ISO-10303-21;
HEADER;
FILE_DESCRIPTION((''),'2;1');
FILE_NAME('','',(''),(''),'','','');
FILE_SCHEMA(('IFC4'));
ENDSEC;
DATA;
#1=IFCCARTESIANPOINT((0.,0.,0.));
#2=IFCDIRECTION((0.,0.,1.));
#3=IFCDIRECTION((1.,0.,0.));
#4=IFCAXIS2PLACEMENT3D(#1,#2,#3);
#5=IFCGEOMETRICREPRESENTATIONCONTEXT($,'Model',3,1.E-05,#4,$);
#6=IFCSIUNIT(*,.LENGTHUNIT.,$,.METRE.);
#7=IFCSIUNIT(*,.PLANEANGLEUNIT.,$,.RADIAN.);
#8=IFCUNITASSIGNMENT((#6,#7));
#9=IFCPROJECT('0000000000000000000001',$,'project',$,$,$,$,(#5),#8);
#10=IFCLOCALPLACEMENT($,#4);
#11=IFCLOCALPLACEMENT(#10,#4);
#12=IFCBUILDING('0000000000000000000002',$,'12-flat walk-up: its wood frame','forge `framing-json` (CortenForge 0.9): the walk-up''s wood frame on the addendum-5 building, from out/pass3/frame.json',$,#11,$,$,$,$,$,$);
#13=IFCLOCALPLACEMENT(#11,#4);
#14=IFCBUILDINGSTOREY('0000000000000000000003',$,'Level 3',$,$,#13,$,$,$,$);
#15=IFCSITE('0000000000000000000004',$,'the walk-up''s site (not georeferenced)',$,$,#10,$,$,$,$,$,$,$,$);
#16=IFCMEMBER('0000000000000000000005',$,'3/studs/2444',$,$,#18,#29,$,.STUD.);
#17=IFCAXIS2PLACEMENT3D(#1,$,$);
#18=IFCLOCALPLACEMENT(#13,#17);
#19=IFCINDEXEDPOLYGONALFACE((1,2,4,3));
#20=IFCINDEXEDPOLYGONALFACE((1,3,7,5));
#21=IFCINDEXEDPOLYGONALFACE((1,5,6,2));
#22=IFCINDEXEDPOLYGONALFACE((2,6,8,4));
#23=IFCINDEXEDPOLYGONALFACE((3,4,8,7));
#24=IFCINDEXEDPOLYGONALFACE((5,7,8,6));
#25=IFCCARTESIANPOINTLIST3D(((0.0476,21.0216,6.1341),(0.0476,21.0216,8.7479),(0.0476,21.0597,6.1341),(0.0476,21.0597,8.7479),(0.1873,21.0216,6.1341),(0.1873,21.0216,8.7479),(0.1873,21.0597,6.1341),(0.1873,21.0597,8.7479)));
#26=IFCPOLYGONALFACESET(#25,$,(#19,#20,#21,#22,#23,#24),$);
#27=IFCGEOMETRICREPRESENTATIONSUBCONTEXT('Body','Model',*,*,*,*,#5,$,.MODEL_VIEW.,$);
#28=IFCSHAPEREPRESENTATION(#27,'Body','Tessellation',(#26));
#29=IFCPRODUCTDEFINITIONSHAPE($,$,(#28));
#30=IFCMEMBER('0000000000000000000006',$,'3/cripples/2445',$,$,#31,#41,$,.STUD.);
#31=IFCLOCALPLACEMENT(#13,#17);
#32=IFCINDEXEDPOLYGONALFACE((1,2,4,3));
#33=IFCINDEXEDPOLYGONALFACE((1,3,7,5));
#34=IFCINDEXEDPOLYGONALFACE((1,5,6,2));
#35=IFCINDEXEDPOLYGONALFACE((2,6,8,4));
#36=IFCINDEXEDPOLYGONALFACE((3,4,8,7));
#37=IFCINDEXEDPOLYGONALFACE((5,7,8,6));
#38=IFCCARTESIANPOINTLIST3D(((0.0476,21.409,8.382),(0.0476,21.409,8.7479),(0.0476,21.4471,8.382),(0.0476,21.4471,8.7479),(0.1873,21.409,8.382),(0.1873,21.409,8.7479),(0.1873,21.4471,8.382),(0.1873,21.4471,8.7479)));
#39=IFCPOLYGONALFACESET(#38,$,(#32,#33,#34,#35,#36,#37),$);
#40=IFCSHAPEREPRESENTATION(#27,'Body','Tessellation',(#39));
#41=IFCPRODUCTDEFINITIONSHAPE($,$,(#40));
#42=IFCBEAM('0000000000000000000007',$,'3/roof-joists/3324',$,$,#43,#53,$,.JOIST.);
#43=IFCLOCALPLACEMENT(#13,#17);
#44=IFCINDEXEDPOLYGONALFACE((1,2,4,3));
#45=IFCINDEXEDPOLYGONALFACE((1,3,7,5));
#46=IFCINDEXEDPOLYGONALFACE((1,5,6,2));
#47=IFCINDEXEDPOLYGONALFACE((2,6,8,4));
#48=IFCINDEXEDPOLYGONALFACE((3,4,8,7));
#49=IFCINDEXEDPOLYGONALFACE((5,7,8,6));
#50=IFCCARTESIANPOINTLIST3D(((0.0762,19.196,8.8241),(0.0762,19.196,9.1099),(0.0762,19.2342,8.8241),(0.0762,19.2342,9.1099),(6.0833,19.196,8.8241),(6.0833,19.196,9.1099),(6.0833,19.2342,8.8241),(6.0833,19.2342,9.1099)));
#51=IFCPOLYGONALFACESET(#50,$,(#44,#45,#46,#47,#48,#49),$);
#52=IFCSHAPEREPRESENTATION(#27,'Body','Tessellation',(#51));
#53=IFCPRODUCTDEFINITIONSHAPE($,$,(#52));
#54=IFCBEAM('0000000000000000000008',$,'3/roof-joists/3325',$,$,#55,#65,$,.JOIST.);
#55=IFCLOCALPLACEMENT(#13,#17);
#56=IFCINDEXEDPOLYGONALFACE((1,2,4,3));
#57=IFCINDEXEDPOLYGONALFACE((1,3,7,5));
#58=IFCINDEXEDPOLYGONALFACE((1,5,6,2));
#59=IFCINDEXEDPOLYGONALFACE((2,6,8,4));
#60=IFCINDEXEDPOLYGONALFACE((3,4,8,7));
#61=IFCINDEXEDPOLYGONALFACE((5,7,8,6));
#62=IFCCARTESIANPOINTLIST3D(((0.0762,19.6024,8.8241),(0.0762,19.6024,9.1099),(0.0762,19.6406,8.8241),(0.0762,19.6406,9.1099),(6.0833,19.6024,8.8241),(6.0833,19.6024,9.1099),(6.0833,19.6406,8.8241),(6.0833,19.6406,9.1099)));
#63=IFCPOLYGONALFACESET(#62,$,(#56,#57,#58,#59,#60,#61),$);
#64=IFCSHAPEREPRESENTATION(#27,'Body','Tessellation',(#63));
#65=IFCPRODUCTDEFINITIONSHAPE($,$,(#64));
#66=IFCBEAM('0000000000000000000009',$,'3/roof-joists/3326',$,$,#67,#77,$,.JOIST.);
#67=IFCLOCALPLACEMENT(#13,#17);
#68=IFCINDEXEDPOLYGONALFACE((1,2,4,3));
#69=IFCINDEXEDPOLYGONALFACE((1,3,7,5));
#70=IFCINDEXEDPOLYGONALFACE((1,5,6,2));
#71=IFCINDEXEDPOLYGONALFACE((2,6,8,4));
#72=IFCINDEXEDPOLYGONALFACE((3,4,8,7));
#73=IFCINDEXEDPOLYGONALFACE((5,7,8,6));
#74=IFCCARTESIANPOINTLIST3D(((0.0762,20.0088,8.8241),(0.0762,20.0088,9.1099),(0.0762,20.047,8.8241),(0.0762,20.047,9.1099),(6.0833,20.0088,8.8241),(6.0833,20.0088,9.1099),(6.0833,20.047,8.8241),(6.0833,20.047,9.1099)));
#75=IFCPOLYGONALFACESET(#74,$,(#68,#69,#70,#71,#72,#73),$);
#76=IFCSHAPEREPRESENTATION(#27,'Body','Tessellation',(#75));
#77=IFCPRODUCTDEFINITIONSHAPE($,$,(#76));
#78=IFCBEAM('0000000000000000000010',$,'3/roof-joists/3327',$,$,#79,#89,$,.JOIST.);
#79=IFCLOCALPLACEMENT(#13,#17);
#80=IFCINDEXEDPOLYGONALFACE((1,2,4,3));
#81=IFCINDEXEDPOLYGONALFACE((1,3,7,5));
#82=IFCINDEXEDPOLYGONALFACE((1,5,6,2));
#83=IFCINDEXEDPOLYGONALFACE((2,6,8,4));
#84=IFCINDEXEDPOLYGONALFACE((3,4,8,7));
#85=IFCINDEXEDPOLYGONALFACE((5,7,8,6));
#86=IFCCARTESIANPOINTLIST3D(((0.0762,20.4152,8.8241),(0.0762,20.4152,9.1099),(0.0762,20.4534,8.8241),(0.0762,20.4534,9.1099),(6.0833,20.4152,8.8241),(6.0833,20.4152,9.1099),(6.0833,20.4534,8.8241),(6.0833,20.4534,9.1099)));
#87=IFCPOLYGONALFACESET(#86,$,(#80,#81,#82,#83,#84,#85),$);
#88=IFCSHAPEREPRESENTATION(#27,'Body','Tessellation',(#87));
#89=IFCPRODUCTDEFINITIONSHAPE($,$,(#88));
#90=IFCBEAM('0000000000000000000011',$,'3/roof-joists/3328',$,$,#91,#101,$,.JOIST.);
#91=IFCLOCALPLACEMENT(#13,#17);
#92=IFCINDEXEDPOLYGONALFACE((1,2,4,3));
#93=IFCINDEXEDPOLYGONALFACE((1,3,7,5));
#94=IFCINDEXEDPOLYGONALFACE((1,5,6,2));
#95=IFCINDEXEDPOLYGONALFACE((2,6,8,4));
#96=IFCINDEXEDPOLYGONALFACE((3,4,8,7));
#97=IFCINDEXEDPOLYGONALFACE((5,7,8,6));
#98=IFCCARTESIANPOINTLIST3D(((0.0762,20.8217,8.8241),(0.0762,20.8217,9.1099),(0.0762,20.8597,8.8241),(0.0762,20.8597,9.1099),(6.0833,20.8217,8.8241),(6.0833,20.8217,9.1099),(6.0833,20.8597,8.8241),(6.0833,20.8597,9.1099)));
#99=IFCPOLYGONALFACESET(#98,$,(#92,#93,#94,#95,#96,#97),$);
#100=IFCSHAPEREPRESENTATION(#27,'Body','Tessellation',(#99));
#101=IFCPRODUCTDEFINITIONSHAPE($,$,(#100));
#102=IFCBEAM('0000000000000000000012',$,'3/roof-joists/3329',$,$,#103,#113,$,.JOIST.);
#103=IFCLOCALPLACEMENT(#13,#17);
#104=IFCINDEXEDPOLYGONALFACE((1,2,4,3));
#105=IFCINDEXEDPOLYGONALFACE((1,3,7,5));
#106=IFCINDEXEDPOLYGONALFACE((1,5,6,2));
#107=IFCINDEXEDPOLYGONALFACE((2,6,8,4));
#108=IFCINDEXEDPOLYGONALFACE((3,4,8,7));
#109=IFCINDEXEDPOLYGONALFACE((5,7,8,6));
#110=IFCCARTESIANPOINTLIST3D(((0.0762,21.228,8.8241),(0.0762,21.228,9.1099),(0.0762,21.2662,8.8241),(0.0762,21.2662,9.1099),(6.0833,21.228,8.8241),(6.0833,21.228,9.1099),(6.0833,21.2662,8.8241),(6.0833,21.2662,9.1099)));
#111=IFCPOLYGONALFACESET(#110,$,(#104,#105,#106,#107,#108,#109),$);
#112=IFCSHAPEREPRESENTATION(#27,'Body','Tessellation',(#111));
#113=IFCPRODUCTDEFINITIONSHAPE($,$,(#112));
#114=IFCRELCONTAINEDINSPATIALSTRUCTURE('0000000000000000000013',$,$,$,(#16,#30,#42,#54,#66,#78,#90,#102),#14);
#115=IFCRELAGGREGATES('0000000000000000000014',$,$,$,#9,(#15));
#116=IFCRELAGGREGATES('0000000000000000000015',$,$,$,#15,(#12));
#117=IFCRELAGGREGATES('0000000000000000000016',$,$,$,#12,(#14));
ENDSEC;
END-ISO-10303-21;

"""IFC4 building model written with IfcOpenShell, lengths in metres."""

from ifc_helpers import new_model, si_unit, frame, frame_2d, origin, origin_with_axes, place, context, subcontext, project, spatial, rectangle, extrude, element, save


model = new_model("IFC4")

# Units and contexts
model_context = context("Model", 3, precision=1e-05, world=origin_with_axes())
body_context = subcontext(model_context, "Body", "Model", "MODEL_VIEW")
ifc_project = project(units=[si_unit("LENGTHUNIT", "METRE"), si_unit("PLANEANGLEUNIT", "RADIAN")], contexts=[model_context])

# Site, building, storey
site_placement = place(None, origin_with_axes())
site = spatial("IfcSite", under=ifc_project, at=site_placement, Name="the walk-up's site (not georeferenced)")
building_placement = place(site_placement, origin_with_axes())
building = spatial("IfcBuilding", under=site, at=building_placement, Name="12-flat walk-up: its wood frame", Description="forge `framing-json` (CortenForge 0.9): the walk-up's wood frame on the addendum-5 building, from out/pass3/frame.json")
storey_placement = place(building_placement, origin_with_axes())
storey = spatial("IfcBuildingStorey", under=building, at=storey_placement, Name="Level 3")

# Members
member_1_placement = place(storey_placement, frame((0.0476, 21.0216, 6.1341), z_axis=(0.0, 0.0, 1.0), x_axis=(1.0, 0.0, 0.0)))
element("IfcMember", 1, at=member_1_placement, inside=storey, Name="3/studs/2444", PredefinedType="STUD", context=body_context, shape_type="SweptSolid", body=[
    extrude(rectangle(XDim=0.1397, YDim=0.0381, at=frame_2d((0.0698, 0.0191))), origin(), (0.0, 0.0, 1.0), 2.6138),
])
member_2_placement = place(storey_placement, frame((0.0476, 21.409, 8.382), z_axis=(0.0, 0.0, 1.0), x_axis=(1.0, 0.0, 0.0)))
element("IfcMember", 2, at=member_2_placement, inside=storey, Name="3/cripples/2445", PredefinedType="STUD", context=body_context, shape_type="SweptSolid", body=[
    extrude(rectangle(XDim=0.1397, YDim=0.0381, at=frame_2d((0.0698, 0.0191))), origin(), (0.0, 0.0, 1.0), 0.3659),
])

# Beams
for number, where, z_axis, x_axis, name in (
    (3, (0.0762, 19.196, 8.8241), (0.0, 0.0, 1.0), (1.0, 0.0, 0.0), "3/roof-joists/3324"),
    (4, (0.0762, 19.6025, 8.8241), (0.0, 0.0, 1.0), (1.0, 0.0, 0.0), "3/roof-joists/3325"),
    (5, (0.0762, 20.0088, 8.8241), (0.0, 0.0, 1.0), (1.0, 0.0, 0.0), "3/roof-joists/3326"),
    (6, (0.0762, 20.4153, 8.8241), (0.0, 0.0, 1.0), (1.0, 0.0, 0.0), "3/roof-joists/3327"),
):
    element("IfcBeam", number, at=place(storey_placement, frame(where, z_axis=z_axis, x_axis=x_axis)), inside=storey, Name=name, PredefinedType="JOIST", context=body_context, shape_type="SweptSolid", body=[
        extrude(rectangle(XDim=6.0071, YDim=0.0381, at=frame_2d((3.0036, 0.0191))), origin(), (0.0, 0.0, 1.0), 0.2858),
    ])
beam_1_placement = place(storey_placement, frame((0.0762, 20.8217, 8.8241), z_axis=(0.0, 0.0, 1.0), x_axis=(1.0, 0.0, 0.0)))
element("IfcBeam", 7, at=beam_1_placement, inside=storey, Name="3/roof-joists/3328", PredefinedType="JOIST", context=body_context, shape_type="SweptSolid", body=[
    extrude(rectangle(XDim=6.0071, YDim=0.0381, at=frame_2d((3.0036, 0.019))), origin(), (0.0, 0.0, 1.0), 0.2858),
])
beam_2_placement = place(storey_placement, frame((0.0762, 21.228, 8.8241), z_axis=(0.0, 0.0, 1.0), x_axis=(1.0, 0.0, 0.0)))
element("IfcBeam", 8, at=beam_2_placement, inside=storey, Name="3/roof-joists/3329", PredefinedType="JOIST", context=body_context, shape_type="SweptSolid", body=[
    extrude(rectangle(XDim=6.0071, YDim=0.0381, at=frame_2d((3.0036, 0.0191))), origin(), (0.0, 0.0, 1.0), 0.2858),
])

save(model, "model.ifc")
